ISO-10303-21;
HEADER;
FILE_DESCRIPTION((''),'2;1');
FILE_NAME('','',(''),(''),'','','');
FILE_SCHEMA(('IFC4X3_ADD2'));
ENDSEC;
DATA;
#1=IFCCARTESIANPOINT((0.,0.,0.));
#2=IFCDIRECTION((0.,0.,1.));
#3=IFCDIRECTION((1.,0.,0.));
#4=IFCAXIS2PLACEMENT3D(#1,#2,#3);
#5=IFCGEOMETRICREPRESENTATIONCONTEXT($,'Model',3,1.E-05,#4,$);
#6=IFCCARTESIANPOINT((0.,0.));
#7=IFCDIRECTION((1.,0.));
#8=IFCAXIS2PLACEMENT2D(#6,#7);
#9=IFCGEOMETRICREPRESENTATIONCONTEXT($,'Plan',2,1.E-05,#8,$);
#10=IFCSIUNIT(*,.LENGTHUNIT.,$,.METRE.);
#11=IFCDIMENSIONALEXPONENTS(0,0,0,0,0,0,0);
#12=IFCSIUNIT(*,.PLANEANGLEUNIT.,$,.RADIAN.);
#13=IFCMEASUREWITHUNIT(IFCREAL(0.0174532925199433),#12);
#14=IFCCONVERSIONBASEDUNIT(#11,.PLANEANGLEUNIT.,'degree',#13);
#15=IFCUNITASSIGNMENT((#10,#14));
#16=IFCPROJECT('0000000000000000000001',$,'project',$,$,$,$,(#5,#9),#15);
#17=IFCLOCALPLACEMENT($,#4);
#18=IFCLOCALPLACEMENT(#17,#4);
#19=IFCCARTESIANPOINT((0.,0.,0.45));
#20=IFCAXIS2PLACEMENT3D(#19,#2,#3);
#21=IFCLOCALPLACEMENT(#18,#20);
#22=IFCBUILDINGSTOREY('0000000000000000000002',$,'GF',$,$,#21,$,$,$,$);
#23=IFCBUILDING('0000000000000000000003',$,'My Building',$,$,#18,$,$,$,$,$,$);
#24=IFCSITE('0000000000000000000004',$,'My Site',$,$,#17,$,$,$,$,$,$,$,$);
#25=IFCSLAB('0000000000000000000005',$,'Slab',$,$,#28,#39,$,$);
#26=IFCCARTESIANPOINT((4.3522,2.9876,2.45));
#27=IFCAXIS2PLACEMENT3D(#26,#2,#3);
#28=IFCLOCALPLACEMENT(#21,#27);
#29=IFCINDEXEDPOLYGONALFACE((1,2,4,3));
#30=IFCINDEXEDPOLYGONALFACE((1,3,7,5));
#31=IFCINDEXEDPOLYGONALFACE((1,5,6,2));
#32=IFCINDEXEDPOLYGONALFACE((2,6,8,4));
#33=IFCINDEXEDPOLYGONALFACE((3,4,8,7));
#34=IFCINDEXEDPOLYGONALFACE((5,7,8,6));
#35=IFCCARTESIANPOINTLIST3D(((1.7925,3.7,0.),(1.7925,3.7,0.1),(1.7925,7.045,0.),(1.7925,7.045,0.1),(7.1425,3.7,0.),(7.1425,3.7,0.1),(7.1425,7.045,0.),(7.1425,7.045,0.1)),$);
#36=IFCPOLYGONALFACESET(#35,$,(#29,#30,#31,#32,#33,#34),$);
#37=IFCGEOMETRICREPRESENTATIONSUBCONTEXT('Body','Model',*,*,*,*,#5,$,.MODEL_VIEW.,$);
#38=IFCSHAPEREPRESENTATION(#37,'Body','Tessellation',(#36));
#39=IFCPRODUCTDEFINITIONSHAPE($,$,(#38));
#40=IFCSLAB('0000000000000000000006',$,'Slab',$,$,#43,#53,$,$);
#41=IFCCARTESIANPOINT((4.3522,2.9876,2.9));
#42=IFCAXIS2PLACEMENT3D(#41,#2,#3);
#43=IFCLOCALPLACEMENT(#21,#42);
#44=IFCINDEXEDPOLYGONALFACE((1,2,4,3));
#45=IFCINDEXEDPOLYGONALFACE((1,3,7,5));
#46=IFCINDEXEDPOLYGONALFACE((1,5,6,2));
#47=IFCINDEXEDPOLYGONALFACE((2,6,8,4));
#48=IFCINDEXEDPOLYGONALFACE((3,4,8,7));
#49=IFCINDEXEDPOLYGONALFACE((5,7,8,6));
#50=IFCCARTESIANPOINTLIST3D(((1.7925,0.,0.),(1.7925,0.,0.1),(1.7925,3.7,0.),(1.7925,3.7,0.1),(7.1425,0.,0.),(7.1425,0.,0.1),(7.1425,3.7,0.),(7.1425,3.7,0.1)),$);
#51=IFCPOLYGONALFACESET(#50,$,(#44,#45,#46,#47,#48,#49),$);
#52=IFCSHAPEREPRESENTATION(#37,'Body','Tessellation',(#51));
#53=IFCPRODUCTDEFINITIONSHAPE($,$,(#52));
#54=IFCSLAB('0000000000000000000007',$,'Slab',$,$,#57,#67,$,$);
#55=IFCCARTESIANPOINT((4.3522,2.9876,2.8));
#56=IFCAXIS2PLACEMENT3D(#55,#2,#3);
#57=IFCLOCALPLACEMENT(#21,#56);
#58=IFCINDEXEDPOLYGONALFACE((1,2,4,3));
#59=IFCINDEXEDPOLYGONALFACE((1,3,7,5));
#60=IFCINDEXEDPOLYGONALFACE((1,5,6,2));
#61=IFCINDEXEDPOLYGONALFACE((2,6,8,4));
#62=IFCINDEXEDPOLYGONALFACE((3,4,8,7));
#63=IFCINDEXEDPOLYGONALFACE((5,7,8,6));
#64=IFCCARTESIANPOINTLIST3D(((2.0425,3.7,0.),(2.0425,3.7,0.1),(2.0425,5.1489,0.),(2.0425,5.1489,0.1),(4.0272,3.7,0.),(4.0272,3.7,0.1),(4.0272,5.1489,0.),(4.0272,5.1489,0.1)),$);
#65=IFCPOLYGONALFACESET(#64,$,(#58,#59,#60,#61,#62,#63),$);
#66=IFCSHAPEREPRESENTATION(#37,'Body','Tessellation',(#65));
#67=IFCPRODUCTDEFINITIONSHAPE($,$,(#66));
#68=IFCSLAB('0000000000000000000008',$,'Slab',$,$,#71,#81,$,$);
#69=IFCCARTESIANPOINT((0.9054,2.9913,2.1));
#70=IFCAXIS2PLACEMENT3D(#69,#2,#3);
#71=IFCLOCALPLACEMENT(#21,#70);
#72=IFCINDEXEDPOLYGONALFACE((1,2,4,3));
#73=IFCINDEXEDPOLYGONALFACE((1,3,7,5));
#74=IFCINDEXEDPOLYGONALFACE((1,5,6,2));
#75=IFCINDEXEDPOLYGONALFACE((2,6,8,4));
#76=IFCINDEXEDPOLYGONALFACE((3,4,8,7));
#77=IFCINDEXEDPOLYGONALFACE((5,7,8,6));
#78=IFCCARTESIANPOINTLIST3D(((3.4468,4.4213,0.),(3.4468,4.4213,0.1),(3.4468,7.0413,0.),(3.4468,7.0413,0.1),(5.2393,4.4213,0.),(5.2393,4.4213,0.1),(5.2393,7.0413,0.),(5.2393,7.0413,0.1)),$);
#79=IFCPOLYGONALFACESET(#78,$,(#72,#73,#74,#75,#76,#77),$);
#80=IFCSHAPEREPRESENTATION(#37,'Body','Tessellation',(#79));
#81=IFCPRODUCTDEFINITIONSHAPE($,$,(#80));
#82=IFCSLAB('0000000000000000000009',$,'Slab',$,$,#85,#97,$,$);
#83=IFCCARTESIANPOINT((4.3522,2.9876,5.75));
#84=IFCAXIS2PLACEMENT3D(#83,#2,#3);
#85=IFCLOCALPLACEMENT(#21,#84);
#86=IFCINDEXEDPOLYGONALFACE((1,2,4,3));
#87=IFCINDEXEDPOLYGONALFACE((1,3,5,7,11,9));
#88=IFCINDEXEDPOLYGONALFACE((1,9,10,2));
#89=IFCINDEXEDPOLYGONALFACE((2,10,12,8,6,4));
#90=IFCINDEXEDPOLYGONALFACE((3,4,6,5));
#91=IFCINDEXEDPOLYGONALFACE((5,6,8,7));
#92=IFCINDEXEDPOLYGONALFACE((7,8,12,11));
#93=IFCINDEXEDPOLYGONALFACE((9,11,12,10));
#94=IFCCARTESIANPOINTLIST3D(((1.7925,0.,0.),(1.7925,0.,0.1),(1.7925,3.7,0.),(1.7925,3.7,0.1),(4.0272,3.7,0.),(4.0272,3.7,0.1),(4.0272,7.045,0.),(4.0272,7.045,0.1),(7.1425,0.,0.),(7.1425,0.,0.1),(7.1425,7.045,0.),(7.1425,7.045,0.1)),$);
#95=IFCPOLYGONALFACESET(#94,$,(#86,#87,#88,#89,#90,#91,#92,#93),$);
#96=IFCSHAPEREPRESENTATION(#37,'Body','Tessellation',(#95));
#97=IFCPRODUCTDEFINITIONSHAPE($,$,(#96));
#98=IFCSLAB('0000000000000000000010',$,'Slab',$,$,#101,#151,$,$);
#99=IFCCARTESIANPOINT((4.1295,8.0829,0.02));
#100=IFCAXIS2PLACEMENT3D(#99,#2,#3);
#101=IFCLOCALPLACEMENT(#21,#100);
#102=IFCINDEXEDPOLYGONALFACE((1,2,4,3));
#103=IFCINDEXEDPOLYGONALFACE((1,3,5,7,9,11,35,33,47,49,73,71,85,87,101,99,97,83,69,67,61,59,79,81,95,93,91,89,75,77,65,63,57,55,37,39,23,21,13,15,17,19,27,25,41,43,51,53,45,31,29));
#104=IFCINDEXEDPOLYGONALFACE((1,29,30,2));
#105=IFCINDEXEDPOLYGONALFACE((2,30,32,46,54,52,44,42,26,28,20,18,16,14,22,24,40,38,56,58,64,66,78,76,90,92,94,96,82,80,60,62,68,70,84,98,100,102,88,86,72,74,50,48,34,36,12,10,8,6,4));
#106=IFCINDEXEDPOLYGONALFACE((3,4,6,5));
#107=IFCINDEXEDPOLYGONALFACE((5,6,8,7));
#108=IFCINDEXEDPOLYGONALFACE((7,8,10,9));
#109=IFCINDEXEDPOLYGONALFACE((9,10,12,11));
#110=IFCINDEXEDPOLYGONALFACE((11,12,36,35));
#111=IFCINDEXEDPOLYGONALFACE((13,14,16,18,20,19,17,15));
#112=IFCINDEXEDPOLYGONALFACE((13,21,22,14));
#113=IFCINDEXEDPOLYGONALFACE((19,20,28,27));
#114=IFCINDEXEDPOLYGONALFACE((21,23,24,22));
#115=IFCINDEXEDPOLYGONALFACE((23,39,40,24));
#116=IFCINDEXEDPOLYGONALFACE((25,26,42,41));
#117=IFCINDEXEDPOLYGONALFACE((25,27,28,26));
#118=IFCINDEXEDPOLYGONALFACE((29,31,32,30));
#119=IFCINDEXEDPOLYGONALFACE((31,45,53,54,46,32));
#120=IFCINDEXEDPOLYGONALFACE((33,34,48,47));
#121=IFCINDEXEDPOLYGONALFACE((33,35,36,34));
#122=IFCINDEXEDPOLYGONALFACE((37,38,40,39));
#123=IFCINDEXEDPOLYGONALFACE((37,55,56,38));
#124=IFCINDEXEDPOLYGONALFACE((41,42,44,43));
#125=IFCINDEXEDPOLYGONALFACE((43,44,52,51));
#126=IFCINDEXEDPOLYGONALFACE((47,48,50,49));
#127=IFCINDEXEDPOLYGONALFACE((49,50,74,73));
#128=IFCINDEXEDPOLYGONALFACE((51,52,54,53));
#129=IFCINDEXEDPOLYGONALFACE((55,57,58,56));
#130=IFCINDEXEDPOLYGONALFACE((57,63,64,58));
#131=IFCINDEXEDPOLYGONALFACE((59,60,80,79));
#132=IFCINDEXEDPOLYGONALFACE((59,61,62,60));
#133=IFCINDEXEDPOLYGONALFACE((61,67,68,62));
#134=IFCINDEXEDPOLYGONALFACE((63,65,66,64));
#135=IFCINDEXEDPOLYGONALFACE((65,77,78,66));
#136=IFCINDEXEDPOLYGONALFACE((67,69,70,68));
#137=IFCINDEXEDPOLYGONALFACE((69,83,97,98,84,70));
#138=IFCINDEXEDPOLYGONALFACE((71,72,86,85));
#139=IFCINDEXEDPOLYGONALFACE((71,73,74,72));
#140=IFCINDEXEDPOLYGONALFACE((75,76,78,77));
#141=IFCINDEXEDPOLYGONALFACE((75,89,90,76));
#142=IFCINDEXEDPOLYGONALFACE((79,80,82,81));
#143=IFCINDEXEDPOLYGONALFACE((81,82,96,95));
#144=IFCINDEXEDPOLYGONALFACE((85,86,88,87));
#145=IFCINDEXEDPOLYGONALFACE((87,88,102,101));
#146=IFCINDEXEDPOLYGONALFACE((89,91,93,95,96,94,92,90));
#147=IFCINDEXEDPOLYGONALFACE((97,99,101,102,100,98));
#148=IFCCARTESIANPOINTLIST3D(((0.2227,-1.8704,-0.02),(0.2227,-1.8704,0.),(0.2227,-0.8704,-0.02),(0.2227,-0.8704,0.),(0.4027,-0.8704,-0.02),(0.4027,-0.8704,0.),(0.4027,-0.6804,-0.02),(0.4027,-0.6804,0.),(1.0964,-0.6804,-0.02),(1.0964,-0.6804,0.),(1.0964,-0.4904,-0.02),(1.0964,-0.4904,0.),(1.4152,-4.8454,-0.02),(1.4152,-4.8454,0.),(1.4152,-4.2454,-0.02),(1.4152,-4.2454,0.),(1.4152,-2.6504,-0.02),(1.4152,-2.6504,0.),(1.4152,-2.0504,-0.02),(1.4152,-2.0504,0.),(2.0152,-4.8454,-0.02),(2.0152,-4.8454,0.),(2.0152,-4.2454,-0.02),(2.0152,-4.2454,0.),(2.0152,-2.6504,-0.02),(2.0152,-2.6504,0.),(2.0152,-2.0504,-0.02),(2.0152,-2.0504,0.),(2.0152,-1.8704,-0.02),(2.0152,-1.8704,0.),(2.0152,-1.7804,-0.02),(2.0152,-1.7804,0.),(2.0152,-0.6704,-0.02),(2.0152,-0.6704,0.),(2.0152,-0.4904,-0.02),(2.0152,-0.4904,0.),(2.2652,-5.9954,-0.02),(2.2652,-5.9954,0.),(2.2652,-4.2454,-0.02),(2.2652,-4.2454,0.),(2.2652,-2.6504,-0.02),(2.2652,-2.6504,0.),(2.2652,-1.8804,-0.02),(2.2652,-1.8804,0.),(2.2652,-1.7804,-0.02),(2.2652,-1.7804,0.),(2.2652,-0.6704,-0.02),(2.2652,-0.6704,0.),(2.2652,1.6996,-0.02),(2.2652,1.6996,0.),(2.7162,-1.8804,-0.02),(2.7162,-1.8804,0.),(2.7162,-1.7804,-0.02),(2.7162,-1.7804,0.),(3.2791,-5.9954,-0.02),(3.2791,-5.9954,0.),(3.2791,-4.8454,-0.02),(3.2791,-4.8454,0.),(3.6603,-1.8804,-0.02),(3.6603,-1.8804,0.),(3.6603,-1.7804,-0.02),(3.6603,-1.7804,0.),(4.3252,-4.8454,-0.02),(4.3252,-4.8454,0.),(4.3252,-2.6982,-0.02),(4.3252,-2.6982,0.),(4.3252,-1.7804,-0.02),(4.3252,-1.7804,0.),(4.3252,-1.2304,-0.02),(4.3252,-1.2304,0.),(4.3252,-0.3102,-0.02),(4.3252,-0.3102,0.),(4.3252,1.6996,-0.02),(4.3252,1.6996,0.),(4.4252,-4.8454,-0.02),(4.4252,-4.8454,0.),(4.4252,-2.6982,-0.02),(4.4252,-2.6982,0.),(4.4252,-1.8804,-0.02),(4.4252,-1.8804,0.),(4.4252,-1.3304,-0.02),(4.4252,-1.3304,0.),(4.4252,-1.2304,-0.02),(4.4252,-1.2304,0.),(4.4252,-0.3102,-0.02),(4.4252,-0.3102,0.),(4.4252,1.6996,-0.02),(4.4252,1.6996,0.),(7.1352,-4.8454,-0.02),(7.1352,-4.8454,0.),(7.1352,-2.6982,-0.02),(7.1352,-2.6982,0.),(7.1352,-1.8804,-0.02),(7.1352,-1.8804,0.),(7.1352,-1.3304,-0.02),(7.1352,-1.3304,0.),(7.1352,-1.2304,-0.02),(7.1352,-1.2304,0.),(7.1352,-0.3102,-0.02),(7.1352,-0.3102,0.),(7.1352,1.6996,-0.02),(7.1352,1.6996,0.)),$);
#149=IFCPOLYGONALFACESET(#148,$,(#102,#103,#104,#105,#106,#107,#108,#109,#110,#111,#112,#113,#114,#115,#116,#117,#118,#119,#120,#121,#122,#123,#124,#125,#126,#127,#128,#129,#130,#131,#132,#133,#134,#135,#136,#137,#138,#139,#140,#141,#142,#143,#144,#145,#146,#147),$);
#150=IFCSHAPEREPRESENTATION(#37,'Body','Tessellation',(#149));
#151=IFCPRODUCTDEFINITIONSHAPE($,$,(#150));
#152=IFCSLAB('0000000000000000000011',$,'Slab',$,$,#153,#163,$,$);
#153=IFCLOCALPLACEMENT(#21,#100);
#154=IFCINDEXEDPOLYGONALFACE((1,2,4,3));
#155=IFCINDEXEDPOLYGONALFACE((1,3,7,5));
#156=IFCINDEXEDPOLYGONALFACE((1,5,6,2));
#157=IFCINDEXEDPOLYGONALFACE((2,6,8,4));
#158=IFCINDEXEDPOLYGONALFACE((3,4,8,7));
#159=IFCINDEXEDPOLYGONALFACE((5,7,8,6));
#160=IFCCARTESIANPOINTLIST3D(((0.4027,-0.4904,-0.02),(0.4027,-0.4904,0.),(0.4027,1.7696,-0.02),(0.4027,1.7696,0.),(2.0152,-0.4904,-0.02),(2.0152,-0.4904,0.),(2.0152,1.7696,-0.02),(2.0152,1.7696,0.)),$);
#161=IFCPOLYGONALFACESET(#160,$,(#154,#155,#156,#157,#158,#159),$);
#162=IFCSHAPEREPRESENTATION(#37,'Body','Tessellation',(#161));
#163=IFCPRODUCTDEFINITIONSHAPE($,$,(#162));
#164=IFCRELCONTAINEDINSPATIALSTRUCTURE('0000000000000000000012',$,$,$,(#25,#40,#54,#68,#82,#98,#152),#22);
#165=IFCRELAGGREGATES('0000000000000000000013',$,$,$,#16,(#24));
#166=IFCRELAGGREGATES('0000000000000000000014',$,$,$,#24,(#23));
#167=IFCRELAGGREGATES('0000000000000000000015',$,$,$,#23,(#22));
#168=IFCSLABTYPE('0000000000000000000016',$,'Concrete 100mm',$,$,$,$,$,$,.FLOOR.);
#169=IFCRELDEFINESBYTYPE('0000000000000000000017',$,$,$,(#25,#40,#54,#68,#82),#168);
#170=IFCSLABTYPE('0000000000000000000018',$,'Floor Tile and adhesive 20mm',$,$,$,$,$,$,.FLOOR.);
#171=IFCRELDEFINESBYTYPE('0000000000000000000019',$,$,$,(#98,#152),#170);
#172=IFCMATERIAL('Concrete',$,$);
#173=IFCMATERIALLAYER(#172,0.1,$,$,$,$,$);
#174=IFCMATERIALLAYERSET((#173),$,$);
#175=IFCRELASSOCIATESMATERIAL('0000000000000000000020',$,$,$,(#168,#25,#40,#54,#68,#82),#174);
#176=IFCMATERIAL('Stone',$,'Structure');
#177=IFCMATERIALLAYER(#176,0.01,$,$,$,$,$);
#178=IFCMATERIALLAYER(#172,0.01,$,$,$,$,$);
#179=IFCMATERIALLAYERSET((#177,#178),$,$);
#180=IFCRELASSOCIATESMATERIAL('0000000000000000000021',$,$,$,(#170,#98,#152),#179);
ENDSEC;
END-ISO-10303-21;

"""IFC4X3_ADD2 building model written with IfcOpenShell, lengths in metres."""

from ifc_helpers import new_model, entity, si_unit, converted_unit, frame, origin_with_axes, origin_2d_with_axis, place, context, subcontext, project, spatial, indexed_curve, outline, extrude, material, layer, layer_set, layer_usage, type_object, element, save


model = new_model("IFC4X3_ADD2")

# Units and contexts
model_context = context("Model", 3, precision=1e-05, world=origin_with_axes())
plan_context = context("Plan", 2, precision=1e-05, world=origin_2d_with_axis())
body_context_1 = subcontext(model_context, "Body", "Model", "MODEL_VIEW")
ifc_project = project(units=[si_unit("LENGTHUNIT", "METRE"), converted_unit("PLANEANGLEUNIT", "degree", entity("IfcReal", 0.0174532925199433), si_unit("PLANEANGLEUNIT", "RADIAN"), dimensions=[0, 0, 0, 0, 0, 0, 0])], contexts=[model_context, plan_context])

# Site, building, storey
site_placement = place(None, origin_with_axes())
site = spatial("IfcSite", under=ifc_project, at=site_placement, Name="My Site")
building_placement = place(site_placement, origin_with_axes())
building = spatial("IfcBuilding", under=site, at=building_placement, Name="My Building")
storey_placement = place(building_placement, frame((0.0, 0.0, 0.45), z_axis=(0.0, 0.0, 1.0), x_axis=(1.0, 0.0, 0.0)))
storey = spatial("IfcBuildingStorey", under=building, at=storey_placement, Name="GF")

# Slabs
ifc_material_1 = material(Name="Concrete")
ifc_layer_1 = layer(ifc_material_1, 0.1)
ifc_layer_set_1 = layer_set([ifc_layer_1])
ifc_layer_usage_1 = layer_usage(ifc_layer_set_1, "AXIS3", "POSITIVE", 0.0)
slab_type_1 = type_object("IfcSlabType", Name="Concrete 100mm", PredefinedType="FLOOR", material=ifc_layer_set_1)
slab_1_placement = place(storey_placement, frame((4.3522, 2.9876, 2.45), z_axis=(0.0, 0.0, 1.0), x_axis=(1.0, 0.0, 0.0)))
element("IfcSlab", 1, at=slab_1_placement, inside=storey, type_object=slab_type_1, material=ifc_layer_usage_1, Name="Slab", context=body_context_1, shape_type="SweptSolid", body=[
    extrude(outline(indexed_curve([(1.7925, 3.7), (7.1425, 3.7), (7.1425, 7.045), (1.7925, 7.045), (1.7925, 3.7)])), origin_with_axes(), (0.0, 0.0, 1.0), 0.1),
])
ifc_layer_usage_2 = layer_usage(ifc_layer_set_1, "AXIS3", "POSITIVE", 0.0)
slab_2_placement = place(storey_placement, frame((4.3522, 2.9876, 2.9), z_axis=(0.0, 0.0, 1.0), x_axis=(1.0, 0.0, 0.0)))
element("IfcSlab", 2, at=slab_2_placement, inside=storey, type_object=slab_type_1, material=ifc_layer_usage_2, Name="Slab", context=body_context_1, shape_type="SweptSolid", body=[
    extrude(outline(indexed_curve([(1.7925, 3.7), (7.1425, 3.7), (7.1425, 0.0), (1.7925, 0.0), (1.7925, 3.7)])), origin_with_axes(), (0.0, 0.0, 1.0), 0.1),
])
ifc_layer_usage_3 = layer_usage(ifc_layer_set_1, "AXIS3", "POSITIVE", 0.0)
slab_3_placement = place(storey_placement, frame((4.3522, 2.9876, 2.8), z_axis=(0.0, 0.0, 1.0), x_axis=(1.0, 0.0, 0.0)))
element("IfcSlab", 3, at=slab_3_placement, inside=storey, type_object=slab_type_1, material=ifc_layer_usage_3, Name="Slab", context=body_context_1, shape_type="SweptSolid", body=[
    extrude(outline(indexed_curve([(2.0425, 5.1489), (4.0272, 5.1489), (4.0272, 3.7), (2.0425, 3.7), (2.0425, 5.1489)])), origin_with_axes(), (0.0, 0.0, 1.0), 0.1),
])
ifc_layer_usage_4 = layer_usage(ifc_layer_set_1, "AXIS3", "POSITIVE", 0.0)
slab_4_placement = place(storey_placement, frame((0.9054, 2.9913, 2.1), z_axis=(0.0, 0.0, 1.0), x_axis=(1.0, 0.0, 0.0)))
element("IfcSlab", 4, at=slab_4_placement, inside=storey, type_object=slab_type_1, material=ifc_layer_usage_4, Name="Slab", context=body_context_1, shape_type="SweptSolid", body=[
    extrude(outline(indexed_curve([(3.4468, 7.0413), (3.4468, 4.4213), (5.2393, 4.4213), (5.2393, 7.0413), (3.4468, 7.0413)])), origin_with_axes(), (0.0, 0.0, 1.0), 0.1),
])
ifc_layer_usage_5 = layer_usage(ifc_layer_set_1, "AXIS3", "POSITIVE", 0.0)
slab_5_placement = place(storey_placement, frame((4.3522, 2.9876, 5.75), z_axis=(0.0, 0.0, 1.0), x_axis=(1.0, 0.0, 0.0)))
element("IfcSlab", 5, at=slab_5_placement, inside=storey, type_object=slab_type_1, material=ifc_layer_usage_5, Name="Slab", context=body_context_1, shape_type="SweptSolid", body=[
    extrude(outline(indexed_curve([(4.0272, 3.7), (4.0272, 7.045), (7.1425, 7.045), (7.1425, 0.0), (1.7925, 0.0), (1.7925, 3.7), (4.0272, 3.7)])), origin_with_axes(), (0.0, 0.0, 1.0), 0.1),
])
ifc_material_2 = material(Name="Stone", Category="Structure")
ifc_layer_2 = layer(ifc_material_2, 0.01)
ifc_layer_3 = layer(ifc_material_1, 0.01)
ifc_layer_set_2 = layer_set([ifc_layer_2, ifc_layer_3])
ifc_layer_usage_6 = layer_usage(ifc_layer_set_2, "AXIS3", "POSITIVE", -0.02)
slab_type_2 = type_object("IfcSlabType", Name="Floor Tile and adhesive 20mm", PredefinedType="FLOOR", material=ifc_layer_set_2)
slab_6_placement = place(storey_placement, frame((4.1295, 8.0829, 0.02), z_axis=(0.0, 0.0, 1.0), x_axis=(1.0, 0.0, 0.0)))
element("IfcSlab", 6, at=slab_6_placement, inside=storey, type_object=slab_type_2, material=ifc_layer_usage_6, Name="Slab", context=body_context_1, shape_type="SweptSolid", body=[
    extrude(outline(indexed_curve([(2.0152, -1.7804), (2.2652, -1.7804), (2.7162, -1.7804), (2.7162, -1.8804), (2.2652, -1.8804), (2.2652, -2.6504), (2.0152, -2.6504), (2.0152, -2.0504), (1.4152, -2.0504), (1.4152, -2.6504), (1.4152, -4.2454), (1.4152, -4.8454), (2.0152, -4.8454), (2.0152, -4.2454), (2.2652, -4.2454), (2.2652, -5.9954), (3.2791, -5.9954), (3.2791, -4.8454), (4.3252, -4.8454), (4.3252, -2.6982), (4.4252, -2.6982), (4.4252, -4.8454), (7.1352, -4.8454), (7.1352, -2.6982), (7.1352, -1.8804), (7.1352, -1.3304), (4.4252, -1.3304), (4.4252, -1.8804), (3.6603, -1.8804), (3.6603, -1.7804), (4.3252, -1.7804), (4.3252, -1.2304), (4.4252, -1.2304), (7.1352, -1.2304), (7.1352, -0.3102), (7.1352, 1.6996), (4.4252, 1.6996), (4.4252, -0.3102), (4.3252, -0.3102), (4.3252, 1.6996), (2.2652, 1.6996), (2.2652, -0.6704), (2.0152, -0.6704), (2.0152, -0.4904), (1.0964, -0.4904), (1.0964, -0.6804), (0.4027, -0.6804), (0.4027, -0.8704), (0.2227, -0.8704), (0.2227, -1.8704), (2.0152, -1.8704), (2.0152, -1.7804)])), frame((0.0, 0.0, -0.02), z_axis=(0.0, 0.0, 1.0), x_axis=(1.0, 0.0, 0.0)), (0.0, 0.0, 1.0), 0.02),
])
ifc_layer_usage_7 = layer_usage(ifc_layer_set_2, "AXIS3", "POSITIVE", -0.02)
slab_7_placement = place(storey_placement, frame((4.1295, 8.0829, 0.02), z_axis=(0.0, 0.0, 1.0), x_axis=(1.0, 0.0, 0.0)))
element("IfcSlab", 7, at=slab_7_placement, inside=storey, type_object=slab_type_2, material=ifc_layer_usage_7, Name="Slab", context=body_context_1, shape_type="SweptSolid", body=[
    extrude(outline(indexed_curve([(2.0152, -0.4904), (2.0152, 1.7696), (0.4027, 1.7696), (0.4027, -0.4904), (2.0152, -0.4904)])), frame((0.0, 0.0, -0.02), z_axis=(0.0, 0.0, 1.0), x_axis=(1.0, 0.0, 0.0)), (0.0, 0.0, 1.0), 0.02),
])

save(model, "model.ifc")
